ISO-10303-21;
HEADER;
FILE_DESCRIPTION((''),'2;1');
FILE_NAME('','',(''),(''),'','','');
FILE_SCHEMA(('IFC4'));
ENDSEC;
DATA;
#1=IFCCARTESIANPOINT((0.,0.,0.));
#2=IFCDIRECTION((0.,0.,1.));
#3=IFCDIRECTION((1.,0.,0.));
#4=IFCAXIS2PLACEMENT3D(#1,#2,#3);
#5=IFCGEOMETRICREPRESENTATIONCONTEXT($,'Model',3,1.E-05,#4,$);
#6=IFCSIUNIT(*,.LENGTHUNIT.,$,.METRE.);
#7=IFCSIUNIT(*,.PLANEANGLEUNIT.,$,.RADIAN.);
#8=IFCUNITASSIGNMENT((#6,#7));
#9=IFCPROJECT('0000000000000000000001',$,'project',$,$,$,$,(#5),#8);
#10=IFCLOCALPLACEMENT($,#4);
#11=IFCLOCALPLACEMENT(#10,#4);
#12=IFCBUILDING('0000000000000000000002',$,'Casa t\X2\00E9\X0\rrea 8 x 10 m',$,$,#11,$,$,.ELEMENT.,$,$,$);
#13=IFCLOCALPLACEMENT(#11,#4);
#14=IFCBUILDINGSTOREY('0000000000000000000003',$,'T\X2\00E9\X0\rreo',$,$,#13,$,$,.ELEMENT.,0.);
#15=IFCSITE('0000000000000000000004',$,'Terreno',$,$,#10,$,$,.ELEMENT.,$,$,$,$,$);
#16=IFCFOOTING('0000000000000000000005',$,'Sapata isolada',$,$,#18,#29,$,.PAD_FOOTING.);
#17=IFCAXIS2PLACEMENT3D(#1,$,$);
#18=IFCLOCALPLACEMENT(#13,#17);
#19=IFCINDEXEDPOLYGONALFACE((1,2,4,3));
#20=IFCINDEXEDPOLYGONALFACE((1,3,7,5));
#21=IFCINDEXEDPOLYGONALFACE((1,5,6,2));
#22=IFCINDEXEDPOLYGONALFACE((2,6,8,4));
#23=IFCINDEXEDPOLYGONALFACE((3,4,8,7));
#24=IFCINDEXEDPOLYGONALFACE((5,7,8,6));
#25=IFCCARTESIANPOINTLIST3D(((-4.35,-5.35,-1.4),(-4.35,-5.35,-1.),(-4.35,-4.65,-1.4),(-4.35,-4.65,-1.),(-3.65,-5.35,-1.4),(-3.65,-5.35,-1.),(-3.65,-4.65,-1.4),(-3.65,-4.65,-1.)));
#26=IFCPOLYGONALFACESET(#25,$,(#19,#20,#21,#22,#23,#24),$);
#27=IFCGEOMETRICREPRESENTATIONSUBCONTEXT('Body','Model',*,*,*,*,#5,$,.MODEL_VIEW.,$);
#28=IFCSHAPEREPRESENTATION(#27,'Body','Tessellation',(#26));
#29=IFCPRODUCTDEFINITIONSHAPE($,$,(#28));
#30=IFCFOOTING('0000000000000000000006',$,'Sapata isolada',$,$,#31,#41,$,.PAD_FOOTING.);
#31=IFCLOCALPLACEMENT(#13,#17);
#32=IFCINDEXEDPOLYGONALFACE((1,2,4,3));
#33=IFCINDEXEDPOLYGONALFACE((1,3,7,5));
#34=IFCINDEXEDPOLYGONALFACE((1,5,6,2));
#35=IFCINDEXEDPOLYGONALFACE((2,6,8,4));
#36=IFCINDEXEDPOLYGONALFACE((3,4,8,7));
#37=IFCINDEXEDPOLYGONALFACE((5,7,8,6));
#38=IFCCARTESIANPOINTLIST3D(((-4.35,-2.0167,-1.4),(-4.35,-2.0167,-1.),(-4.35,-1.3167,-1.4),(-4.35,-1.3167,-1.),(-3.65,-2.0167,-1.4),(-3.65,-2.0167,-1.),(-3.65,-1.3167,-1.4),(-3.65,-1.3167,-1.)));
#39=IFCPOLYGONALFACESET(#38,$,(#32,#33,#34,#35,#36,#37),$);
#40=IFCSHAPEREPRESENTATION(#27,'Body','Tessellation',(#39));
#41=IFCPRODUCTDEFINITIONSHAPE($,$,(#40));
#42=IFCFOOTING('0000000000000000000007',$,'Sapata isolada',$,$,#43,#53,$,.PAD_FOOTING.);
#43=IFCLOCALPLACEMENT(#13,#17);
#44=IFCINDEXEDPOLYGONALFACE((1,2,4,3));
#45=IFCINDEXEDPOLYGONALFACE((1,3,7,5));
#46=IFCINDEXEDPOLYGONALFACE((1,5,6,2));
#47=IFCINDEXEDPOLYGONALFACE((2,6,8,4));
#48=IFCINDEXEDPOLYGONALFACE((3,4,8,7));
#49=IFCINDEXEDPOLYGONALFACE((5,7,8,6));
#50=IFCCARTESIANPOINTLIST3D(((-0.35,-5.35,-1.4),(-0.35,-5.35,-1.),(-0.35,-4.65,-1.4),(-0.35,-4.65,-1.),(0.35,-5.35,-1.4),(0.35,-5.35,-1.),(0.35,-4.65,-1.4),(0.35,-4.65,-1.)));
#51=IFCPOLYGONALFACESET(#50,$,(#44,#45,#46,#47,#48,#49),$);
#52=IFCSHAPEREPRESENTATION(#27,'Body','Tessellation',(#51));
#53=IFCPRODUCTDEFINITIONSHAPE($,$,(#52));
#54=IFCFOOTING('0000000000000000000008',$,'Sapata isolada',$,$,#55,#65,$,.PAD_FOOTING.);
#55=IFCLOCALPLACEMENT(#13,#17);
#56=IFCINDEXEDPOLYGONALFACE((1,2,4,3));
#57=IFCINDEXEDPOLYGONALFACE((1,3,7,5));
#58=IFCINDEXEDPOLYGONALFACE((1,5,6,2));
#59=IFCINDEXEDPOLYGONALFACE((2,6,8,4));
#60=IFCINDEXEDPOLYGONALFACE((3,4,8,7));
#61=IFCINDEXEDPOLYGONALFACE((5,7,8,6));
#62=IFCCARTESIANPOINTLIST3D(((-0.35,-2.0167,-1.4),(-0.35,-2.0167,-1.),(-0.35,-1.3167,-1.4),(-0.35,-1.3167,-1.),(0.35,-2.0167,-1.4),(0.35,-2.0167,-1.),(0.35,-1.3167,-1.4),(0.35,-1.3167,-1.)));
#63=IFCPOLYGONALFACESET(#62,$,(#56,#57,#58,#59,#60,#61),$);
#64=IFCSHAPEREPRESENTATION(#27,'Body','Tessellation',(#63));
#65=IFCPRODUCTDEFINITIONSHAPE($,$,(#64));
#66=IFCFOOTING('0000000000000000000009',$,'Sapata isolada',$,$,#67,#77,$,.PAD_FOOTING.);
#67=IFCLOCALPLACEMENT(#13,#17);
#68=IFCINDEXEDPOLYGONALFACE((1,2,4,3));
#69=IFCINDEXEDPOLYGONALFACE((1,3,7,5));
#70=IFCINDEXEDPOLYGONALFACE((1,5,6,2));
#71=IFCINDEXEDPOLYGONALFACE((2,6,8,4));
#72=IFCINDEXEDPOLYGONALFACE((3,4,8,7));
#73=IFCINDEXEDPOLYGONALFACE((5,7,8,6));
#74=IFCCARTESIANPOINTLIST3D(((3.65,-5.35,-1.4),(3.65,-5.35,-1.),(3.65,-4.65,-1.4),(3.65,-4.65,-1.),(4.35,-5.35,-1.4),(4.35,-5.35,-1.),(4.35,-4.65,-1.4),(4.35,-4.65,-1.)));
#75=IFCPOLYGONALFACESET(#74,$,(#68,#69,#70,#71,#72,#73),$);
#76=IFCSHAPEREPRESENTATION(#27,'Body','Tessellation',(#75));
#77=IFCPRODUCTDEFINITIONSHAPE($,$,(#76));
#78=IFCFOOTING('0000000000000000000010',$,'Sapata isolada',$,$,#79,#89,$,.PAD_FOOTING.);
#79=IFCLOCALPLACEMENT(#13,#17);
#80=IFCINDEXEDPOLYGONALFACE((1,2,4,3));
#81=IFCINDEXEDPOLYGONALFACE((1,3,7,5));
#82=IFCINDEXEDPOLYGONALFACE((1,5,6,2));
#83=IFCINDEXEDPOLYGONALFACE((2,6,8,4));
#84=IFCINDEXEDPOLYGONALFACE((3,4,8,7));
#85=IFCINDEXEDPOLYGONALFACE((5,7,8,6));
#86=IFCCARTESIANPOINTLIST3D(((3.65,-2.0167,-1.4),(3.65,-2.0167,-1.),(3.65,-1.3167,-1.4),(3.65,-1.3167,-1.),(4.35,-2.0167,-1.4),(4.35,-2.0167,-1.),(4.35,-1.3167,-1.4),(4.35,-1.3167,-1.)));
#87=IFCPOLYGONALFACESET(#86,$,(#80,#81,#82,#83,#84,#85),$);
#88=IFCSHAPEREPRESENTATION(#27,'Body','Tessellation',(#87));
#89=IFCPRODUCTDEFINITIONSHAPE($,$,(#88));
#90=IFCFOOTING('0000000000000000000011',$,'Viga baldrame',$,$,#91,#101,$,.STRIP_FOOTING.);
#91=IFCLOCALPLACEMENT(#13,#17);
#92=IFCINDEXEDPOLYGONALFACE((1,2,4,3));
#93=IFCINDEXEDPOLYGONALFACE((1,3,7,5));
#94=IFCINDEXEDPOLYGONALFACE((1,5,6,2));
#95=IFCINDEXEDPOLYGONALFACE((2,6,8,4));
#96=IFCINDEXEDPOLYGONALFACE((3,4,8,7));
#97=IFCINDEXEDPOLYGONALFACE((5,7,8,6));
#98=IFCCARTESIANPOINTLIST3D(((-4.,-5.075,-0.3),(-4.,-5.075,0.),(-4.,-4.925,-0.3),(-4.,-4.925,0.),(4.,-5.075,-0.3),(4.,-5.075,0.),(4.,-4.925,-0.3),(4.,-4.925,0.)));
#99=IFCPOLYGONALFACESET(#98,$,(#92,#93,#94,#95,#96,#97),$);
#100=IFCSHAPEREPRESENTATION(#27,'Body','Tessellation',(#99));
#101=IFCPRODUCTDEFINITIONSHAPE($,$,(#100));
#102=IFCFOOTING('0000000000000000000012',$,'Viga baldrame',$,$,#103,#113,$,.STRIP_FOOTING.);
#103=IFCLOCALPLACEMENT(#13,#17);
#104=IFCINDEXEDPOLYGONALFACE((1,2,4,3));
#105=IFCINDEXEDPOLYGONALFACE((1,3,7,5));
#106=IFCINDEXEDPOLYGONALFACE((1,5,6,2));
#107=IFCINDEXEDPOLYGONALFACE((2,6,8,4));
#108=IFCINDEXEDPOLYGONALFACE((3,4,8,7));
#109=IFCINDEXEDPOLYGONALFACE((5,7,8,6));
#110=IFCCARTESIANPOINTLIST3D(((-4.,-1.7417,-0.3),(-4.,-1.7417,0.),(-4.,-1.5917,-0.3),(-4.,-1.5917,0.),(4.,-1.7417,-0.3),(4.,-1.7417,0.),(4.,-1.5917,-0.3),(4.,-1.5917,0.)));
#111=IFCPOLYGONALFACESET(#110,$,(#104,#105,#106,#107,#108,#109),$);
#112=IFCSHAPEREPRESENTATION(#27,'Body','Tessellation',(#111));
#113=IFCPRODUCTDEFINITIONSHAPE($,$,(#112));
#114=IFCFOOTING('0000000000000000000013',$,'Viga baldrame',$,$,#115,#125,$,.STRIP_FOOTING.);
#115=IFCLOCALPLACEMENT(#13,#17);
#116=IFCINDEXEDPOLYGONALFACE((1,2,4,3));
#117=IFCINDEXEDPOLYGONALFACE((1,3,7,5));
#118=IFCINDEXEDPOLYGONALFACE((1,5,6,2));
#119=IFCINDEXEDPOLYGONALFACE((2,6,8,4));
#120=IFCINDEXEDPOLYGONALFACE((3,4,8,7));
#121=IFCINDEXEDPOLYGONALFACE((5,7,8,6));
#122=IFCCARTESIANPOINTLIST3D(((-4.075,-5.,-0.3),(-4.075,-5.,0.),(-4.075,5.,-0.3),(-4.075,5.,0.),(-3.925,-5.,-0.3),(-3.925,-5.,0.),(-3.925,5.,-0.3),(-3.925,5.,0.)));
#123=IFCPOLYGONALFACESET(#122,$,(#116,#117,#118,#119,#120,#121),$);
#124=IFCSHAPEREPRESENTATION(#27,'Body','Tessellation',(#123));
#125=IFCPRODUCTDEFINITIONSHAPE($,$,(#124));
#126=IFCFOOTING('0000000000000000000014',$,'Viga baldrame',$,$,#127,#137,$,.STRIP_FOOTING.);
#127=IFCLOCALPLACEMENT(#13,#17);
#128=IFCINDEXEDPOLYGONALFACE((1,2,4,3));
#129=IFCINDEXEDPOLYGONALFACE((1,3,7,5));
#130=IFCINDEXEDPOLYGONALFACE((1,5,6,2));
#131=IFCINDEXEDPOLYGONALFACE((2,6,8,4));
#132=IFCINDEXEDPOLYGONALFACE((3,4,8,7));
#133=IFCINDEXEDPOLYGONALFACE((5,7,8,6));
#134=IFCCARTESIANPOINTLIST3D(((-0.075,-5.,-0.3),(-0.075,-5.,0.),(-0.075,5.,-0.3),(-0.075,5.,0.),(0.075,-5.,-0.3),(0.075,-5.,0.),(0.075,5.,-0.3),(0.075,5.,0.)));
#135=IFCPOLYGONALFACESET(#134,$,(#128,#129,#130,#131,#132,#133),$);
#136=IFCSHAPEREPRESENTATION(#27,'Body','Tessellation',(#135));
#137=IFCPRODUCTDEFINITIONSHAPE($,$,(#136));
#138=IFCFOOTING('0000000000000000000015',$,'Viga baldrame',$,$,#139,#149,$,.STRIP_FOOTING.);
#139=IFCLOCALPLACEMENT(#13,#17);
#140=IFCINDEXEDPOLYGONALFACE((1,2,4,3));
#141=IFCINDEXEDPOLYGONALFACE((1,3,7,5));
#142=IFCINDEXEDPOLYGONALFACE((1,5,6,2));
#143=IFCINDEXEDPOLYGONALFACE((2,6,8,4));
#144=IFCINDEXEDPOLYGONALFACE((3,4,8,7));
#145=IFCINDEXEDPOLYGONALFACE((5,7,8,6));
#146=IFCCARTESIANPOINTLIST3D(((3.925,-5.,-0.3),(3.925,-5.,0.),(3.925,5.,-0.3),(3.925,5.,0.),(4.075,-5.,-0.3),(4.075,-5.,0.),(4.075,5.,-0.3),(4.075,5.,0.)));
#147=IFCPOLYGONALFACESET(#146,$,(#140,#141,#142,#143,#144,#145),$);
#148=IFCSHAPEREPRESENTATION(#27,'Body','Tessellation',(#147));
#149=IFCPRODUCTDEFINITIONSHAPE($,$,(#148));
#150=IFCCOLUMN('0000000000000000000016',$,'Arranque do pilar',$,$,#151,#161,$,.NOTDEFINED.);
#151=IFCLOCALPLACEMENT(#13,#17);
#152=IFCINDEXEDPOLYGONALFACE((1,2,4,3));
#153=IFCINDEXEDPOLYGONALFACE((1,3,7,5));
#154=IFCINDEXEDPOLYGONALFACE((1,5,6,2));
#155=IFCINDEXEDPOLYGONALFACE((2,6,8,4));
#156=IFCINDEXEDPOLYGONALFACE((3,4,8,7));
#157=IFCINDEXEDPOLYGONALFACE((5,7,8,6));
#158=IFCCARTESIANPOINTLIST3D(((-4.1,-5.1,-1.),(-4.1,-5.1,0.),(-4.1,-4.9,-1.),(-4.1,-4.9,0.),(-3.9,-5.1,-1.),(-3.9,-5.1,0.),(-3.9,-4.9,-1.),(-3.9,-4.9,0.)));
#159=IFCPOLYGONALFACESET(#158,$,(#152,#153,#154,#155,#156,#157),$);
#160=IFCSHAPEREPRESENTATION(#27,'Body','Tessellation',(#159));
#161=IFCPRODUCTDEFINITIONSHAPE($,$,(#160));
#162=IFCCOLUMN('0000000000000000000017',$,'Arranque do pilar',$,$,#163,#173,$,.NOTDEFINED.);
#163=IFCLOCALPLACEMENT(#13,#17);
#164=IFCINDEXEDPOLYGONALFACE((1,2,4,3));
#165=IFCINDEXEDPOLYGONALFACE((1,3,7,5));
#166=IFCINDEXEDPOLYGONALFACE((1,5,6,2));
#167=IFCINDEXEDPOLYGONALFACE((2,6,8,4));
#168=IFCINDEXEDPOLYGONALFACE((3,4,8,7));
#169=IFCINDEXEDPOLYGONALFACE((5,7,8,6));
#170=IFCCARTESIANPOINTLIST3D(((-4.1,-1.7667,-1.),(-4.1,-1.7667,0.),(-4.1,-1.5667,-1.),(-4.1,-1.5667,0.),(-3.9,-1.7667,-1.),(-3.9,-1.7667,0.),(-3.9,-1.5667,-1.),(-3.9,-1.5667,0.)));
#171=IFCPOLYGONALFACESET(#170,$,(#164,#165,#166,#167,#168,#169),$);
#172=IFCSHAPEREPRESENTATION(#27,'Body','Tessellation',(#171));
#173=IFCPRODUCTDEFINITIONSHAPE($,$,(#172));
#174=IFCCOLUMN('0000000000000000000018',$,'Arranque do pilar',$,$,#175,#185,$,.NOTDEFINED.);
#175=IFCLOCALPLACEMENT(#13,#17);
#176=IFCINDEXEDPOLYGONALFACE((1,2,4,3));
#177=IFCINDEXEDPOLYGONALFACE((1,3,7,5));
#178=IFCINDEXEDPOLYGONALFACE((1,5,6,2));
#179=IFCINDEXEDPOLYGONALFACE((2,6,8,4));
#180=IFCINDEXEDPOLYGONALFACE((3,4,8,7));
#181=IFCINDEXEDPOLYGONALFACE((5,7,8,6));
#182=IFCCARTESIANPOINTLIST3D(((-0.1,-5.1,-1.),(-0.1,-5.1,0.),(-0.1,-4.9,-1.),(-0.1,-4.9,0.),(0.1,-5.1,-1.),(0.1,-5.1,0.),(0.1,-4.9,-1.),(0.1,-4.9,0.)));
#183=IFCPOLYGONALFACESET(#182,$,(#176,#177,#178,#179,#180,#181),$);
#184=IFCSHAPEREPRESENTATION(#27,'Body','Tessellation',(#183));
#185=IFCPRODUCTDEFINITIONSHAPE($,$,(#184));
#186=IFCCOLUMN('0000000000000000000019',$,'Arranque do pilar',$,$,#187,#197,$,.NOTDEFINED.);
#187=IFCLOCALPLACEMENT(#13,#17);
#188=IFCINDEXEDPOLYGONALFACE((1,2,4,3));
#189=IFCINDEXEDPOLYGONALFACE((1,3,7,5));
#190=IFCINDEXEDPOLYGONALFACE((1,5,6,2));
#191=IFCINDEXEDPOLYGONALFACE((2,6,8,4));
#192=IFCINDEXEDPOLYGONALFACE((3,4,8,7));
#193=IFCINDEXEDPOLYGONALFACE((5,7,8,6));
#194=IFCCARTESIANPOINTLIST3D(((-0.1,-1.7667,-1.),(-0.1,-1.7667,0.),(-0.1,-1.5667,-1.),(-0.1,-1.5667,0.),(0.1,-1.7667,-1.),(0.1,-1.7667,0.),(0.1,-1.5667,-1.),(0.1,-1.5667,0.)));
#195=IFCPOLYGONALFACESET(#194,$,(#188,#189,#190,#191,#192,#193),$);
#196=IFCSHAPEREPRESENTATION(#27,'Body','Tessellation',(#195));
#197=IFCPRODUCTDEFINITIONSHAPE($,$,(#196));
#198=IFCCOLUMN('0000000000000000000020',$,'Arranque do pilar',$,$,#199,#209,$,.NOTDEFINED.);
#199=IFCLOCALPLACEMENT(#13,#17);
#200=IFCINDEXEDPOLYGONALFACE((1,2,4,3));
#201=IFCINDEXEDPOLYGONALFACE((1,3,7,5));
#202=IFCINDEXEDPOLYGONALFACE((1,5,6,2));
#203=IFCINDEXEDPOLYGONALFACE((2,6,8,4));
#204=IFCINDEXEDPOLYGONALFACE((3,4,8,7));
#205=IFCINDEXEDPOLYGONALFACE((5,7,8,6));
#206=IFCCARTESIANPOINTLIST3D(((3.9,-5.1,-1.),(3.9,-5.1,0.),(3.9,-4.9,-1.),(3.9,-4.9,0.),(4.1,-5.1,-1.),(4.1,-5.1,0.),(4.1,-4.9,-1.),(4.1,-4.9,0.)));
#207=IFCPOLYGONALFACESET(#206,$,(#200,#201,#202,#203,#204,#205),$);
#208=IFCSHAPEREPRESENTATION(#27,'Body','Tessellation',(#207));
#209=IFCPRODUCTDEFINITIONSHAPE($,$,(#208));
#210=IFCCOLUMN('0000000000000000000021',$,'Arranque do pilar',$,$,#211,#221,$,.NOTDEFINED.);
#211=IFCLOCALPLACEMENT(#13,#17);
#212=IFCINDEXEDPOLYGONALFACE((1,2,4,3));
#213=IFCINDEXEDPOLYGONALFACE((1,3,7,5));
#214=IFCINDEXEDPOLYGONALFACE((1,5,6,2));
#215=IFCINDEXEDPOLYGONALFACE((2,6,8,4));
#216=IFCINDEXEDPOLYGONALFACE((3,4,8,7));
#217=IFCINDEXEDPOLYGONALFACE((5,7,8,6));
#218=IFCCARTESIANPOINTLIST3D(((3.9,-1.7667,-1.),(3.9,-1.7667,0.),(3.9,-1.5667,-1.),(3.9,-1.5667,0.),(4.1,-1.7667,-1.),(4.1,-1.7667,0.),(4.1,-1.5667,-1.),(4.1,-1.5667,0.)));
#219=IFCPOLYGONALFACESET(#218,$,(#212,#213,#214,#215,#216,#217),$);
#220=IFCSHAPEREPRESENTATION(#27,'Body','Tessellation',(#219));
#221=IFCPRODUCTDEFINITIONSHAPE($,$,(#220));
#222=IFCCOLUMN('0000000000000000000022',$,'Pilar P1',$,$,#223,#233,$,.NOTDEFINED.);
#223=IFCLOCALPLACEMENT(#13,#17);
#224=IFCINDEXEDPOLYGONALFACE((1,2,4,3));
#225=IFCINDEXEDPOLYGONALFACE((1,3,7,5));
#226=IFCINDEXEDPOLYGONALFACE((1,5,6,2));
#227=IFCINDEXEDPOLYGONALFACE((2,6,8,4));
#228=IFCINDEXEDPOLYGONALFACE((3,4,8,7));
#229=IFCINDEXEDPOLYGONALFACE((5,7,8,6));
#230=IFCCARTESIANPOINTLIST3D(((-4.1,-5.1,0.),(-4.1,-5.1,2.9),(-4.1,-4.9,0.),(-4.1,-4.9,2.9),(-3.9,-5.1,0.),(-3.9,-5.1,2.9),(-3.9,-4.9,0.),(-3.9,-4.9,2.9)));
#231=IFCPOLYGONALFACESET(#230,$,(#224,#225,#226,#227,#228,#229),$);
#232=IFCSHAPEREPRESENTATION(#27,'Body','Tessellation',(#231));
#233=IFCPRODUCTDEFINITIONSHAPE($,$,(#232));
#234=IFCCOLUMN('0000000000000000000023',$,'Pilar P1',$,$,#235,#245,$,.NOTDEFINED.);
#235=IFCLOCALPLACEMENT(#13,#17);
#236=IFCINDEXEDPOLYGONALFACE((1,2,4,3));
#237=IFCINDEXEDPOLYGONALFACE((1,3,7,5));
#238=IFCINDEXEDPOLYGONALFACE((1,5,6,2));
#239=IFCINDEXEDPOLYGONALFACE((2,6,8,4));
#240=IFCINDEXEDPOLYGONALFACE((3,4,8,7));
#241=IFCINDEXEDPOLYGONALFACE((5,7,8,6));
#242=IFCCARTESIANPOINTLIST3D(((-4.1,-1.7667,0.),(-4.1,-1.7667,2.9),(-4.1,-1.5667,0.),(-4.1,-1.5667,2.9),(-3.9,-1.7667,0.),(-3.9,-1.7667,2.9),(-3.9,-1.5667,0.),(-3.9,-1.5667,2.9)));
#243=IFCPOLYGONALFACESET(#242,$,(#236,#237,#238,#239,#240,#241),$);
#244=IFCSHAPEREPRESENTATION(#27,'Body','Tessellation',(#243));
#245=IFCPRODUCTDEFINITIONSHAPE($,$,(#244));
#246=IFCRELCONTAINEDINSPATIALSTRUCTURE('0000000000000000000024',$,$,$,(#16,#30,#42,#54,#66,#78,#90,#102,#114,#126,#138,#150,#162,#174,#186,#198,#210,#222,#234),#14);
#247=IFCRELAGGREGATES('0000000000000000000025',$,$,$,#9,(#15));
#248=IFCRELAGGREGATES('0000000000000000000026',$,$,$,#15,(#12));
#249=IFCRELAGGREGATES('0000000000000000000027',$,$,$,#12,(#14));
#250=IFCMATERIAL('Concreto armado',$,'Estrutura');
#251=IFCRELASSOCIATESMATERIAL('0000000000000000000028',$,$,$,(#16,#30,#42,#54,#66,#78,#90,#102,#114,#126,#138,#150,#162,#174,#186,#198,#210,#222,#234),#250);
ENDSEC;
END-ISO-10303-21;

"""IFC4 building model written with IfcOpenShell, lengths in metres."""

from ifc_helpers import new_model, si_unit, frame, origin_with_axes, origin_2d, place, context, subcontext, project, spatial, rectangle, extrude, material, element, save


model = new_model("IFC4")

# Units and contexts
model_context = context("Model", 3, precision=1e-05, world=origin_with_axes())
body_context = subcontext(model_context, "Body", "Model", "MODEL_VIEW")
ifc_project = project(units=[si_unit("LENGTHUNIT", "METRE"), si_unit("PLANEANGLEUNIT", "RADIAN")], contexts=[model_context])

# Site, building, storey
site_placement = place(None, origin_with_axes())
site = spatial("IfcSite", under=ifc_project, at=site_placement, Name="Terreno", CompositionType="ELEMENT")
building_placement = place(site_placement, origin_with_axes())
building = spatial("IfcBuilding", under=site, at=building_placement, Name="Casa térrea 8 x 10 m", CompositionType="ELEMENT")
storey_placement = place(building_placement, origin_with_axes())
storey = spatial("IfcBuildingStorey", under=building, at=storey_placement, Name="Térreo", CompositionType="ELEMENT", Elevation=0.0)

# Footings
ifc_material_1 = material(Name="Concreto armado", Category="Estrutura")
for number, where, z_axis, x_axis, name in (
    (1, (-4.0, -5.0, -1.4), (0.0, 0.0, 1.0), (1.0, 0.0, 0.0), "Sapata isolada"),
    (2, (-4.0, -1.6667, -1.4), (0.0, 0.0, 1.0), (1.0, 0.0, 0.0), "Sapata isolada"),
    (3, (0.0, -5.0, -1.4), (0.0, 0.0, 1.0), (1.0, 0.0, 0.0), "Sapata isolada"),
    (4, (0.0, -1.6667, -1.4), (0.0, 0.0, 1.0), (1.0, 0.0, 0.0), "Sapata isolada"),
    (5, (4.0, -5.0, -1.4), (0.0, 0.0, 1.0), (1.0, 0.0, 0.0), "Sapata isolada"),
    (6, (4.0, -1.6667, -1.4), (0.0, 0.0, 1.0), (1.0, 0.0, 0.0), "Sapata isolada"),
):
    element("IfcFooting", number, at=place(storey_placement, frame(where, z_axis=z_axis, x_axis=x_axis)), inside=storey, material=ifc_material_1, Name=name, PredefinedType="PAD_FOOTING", context=body_context, shape_type="SweptSolid", body=[
        extrude(rectangle(XDim=0.7, YDim=0.7, at=origin_2d()), None, (0.0, 0.0, 1.0), 0.4),
    ])
for number, where, z_axis, x_axis, name in (
    (7, (0.0, -5.0, -0.3), (0.0, 0.0, 1.0), (1.0, 0.0, 0.0), "Viga baldrame"),
    (8, (0.0, -1.6667, -0.3), (0.0, 0.0, 1.0), (1.0, 0.0, 0.0), "Viga baldrame"),
):
    element("IfcFooting", number, at=place(storey_placement, frame(where, z_axis=z_axis, x_axis=x_axis)), inside=storey, material=ifc_material_1, Name=name, PredefinedType="STRIP_FOOTING", context=body_context, shape_type="SweptSolid", body=[
        extrude(rectangle(XDim=8.0, YDim=0.15, at=origin_2d()), None, (0.0, 0.0, 1.0), 0.3),
    ])
for number, where, z_axis, x_axis, name in (
    (9, (-4.0, 0.0, -0.3), (0.0, 0.0, 1.0), (1.0, 0.0, 0.0), "Viga baldrame"),
    (10, (0.0, 0.0, -0.3), (0.0, 0.0, 1.0), (1.0, 0.0, 0.0), "Viga baldrame"),
    (11, (4.0, 0.0, -0.3), (0.0, 0.0, 1.0), (1.0, 0.0, 0.0), "Viga baldrame"),
):
    element("IfcFooting", number, at=place(storey_placement, frame(where, z_axis=z_axis, x_axis=x_axis)), inside=storey, material=ifc_material_1, Name=name, PredefinedType="STRIP_FOOTING", context=body_context, shape_type="SweptSolid", body=[
        extrude(rectangle(XDim=0.15, YDim=10.0, at=origin_2d()), None, (0.0, 0.0, 1.0), 0.3),
    ])

# Columns
for number, where, z_axis, x_axis, name in (
    (12, (-4.0, -5.0, -1.0), (0.0, 0.0, 1.0), (1.0, 0.0, 0.0), "Arranque do pilar"),
    (13, (-4.0, -1.6667, -1.0), (0.0, 0.0, 1.0), (1.0, 0.0, 0.0), "Arranque do pilar"),
    (14, (0.0, -5.0, -1.0), (0.0, 0.0, 1.0), (1.0, 0.0, 0.0), "Arranque do pilar"),
    (15, (0.0, -1.6667, -1.0), (0.0, 0.0, 1.0), (1.0, 0.0, 0.0), "Arranque do pilar"),
    (16, (4.0, -5.0, -1.0), (0.0, 0.0, 1.0), (1.0, 0.0, 0.0), "Arranque do pilar"),
    (17, (4.0, -1.6667, -1.0), (0.0, 0.0, 1.0), (1.0, 0.0, 0.0), "Arranque do pilar"),
):
    element("IfcColumn", number, at=place(storey_placement, frame(where, z_axis=z_axis, x_axis=x_axis)), inside=storey, material=ifc_material_1, Name=name, PredefinedType="NOTDEFINED", context=body_context, shape_type="SweptSolid", body=[
        extrude(rectangle(XDim=0.2, YDim=0.2, at=origin_2d()), None, (0.0, 0.0, 1.0), 1.0),
    ])
for number, where, z_axis, x_axis, name in (
    (18, (-4.0, -5.0, 0.0), (0.0, 0.0, 1.0), (1.0, 0.0, 0.0), "Pilar P1"),
    (19, (-4.0, -1.6667, 0.0), (0.0, 0.0, 1.0), (1.0, 0.0, 0.0), "Pilar P1"),
):
    element("IfcColumn", number, at=place(storey_placement, frame(where, z_axis=z_axis, x_axis=x_axis)), inside=storey, material=ifc_material_1, Name=name, PredefinedType="NOTDEFINED", context=body_context, shape_type="SweptSolid", body=[
        extrude(rectangle(XDim=0.2, YDim=0.2, at=origin_2d()), None, (0.0, 0.0, 1.0), 2.9),
    ])

save(model, "model.ifc")
